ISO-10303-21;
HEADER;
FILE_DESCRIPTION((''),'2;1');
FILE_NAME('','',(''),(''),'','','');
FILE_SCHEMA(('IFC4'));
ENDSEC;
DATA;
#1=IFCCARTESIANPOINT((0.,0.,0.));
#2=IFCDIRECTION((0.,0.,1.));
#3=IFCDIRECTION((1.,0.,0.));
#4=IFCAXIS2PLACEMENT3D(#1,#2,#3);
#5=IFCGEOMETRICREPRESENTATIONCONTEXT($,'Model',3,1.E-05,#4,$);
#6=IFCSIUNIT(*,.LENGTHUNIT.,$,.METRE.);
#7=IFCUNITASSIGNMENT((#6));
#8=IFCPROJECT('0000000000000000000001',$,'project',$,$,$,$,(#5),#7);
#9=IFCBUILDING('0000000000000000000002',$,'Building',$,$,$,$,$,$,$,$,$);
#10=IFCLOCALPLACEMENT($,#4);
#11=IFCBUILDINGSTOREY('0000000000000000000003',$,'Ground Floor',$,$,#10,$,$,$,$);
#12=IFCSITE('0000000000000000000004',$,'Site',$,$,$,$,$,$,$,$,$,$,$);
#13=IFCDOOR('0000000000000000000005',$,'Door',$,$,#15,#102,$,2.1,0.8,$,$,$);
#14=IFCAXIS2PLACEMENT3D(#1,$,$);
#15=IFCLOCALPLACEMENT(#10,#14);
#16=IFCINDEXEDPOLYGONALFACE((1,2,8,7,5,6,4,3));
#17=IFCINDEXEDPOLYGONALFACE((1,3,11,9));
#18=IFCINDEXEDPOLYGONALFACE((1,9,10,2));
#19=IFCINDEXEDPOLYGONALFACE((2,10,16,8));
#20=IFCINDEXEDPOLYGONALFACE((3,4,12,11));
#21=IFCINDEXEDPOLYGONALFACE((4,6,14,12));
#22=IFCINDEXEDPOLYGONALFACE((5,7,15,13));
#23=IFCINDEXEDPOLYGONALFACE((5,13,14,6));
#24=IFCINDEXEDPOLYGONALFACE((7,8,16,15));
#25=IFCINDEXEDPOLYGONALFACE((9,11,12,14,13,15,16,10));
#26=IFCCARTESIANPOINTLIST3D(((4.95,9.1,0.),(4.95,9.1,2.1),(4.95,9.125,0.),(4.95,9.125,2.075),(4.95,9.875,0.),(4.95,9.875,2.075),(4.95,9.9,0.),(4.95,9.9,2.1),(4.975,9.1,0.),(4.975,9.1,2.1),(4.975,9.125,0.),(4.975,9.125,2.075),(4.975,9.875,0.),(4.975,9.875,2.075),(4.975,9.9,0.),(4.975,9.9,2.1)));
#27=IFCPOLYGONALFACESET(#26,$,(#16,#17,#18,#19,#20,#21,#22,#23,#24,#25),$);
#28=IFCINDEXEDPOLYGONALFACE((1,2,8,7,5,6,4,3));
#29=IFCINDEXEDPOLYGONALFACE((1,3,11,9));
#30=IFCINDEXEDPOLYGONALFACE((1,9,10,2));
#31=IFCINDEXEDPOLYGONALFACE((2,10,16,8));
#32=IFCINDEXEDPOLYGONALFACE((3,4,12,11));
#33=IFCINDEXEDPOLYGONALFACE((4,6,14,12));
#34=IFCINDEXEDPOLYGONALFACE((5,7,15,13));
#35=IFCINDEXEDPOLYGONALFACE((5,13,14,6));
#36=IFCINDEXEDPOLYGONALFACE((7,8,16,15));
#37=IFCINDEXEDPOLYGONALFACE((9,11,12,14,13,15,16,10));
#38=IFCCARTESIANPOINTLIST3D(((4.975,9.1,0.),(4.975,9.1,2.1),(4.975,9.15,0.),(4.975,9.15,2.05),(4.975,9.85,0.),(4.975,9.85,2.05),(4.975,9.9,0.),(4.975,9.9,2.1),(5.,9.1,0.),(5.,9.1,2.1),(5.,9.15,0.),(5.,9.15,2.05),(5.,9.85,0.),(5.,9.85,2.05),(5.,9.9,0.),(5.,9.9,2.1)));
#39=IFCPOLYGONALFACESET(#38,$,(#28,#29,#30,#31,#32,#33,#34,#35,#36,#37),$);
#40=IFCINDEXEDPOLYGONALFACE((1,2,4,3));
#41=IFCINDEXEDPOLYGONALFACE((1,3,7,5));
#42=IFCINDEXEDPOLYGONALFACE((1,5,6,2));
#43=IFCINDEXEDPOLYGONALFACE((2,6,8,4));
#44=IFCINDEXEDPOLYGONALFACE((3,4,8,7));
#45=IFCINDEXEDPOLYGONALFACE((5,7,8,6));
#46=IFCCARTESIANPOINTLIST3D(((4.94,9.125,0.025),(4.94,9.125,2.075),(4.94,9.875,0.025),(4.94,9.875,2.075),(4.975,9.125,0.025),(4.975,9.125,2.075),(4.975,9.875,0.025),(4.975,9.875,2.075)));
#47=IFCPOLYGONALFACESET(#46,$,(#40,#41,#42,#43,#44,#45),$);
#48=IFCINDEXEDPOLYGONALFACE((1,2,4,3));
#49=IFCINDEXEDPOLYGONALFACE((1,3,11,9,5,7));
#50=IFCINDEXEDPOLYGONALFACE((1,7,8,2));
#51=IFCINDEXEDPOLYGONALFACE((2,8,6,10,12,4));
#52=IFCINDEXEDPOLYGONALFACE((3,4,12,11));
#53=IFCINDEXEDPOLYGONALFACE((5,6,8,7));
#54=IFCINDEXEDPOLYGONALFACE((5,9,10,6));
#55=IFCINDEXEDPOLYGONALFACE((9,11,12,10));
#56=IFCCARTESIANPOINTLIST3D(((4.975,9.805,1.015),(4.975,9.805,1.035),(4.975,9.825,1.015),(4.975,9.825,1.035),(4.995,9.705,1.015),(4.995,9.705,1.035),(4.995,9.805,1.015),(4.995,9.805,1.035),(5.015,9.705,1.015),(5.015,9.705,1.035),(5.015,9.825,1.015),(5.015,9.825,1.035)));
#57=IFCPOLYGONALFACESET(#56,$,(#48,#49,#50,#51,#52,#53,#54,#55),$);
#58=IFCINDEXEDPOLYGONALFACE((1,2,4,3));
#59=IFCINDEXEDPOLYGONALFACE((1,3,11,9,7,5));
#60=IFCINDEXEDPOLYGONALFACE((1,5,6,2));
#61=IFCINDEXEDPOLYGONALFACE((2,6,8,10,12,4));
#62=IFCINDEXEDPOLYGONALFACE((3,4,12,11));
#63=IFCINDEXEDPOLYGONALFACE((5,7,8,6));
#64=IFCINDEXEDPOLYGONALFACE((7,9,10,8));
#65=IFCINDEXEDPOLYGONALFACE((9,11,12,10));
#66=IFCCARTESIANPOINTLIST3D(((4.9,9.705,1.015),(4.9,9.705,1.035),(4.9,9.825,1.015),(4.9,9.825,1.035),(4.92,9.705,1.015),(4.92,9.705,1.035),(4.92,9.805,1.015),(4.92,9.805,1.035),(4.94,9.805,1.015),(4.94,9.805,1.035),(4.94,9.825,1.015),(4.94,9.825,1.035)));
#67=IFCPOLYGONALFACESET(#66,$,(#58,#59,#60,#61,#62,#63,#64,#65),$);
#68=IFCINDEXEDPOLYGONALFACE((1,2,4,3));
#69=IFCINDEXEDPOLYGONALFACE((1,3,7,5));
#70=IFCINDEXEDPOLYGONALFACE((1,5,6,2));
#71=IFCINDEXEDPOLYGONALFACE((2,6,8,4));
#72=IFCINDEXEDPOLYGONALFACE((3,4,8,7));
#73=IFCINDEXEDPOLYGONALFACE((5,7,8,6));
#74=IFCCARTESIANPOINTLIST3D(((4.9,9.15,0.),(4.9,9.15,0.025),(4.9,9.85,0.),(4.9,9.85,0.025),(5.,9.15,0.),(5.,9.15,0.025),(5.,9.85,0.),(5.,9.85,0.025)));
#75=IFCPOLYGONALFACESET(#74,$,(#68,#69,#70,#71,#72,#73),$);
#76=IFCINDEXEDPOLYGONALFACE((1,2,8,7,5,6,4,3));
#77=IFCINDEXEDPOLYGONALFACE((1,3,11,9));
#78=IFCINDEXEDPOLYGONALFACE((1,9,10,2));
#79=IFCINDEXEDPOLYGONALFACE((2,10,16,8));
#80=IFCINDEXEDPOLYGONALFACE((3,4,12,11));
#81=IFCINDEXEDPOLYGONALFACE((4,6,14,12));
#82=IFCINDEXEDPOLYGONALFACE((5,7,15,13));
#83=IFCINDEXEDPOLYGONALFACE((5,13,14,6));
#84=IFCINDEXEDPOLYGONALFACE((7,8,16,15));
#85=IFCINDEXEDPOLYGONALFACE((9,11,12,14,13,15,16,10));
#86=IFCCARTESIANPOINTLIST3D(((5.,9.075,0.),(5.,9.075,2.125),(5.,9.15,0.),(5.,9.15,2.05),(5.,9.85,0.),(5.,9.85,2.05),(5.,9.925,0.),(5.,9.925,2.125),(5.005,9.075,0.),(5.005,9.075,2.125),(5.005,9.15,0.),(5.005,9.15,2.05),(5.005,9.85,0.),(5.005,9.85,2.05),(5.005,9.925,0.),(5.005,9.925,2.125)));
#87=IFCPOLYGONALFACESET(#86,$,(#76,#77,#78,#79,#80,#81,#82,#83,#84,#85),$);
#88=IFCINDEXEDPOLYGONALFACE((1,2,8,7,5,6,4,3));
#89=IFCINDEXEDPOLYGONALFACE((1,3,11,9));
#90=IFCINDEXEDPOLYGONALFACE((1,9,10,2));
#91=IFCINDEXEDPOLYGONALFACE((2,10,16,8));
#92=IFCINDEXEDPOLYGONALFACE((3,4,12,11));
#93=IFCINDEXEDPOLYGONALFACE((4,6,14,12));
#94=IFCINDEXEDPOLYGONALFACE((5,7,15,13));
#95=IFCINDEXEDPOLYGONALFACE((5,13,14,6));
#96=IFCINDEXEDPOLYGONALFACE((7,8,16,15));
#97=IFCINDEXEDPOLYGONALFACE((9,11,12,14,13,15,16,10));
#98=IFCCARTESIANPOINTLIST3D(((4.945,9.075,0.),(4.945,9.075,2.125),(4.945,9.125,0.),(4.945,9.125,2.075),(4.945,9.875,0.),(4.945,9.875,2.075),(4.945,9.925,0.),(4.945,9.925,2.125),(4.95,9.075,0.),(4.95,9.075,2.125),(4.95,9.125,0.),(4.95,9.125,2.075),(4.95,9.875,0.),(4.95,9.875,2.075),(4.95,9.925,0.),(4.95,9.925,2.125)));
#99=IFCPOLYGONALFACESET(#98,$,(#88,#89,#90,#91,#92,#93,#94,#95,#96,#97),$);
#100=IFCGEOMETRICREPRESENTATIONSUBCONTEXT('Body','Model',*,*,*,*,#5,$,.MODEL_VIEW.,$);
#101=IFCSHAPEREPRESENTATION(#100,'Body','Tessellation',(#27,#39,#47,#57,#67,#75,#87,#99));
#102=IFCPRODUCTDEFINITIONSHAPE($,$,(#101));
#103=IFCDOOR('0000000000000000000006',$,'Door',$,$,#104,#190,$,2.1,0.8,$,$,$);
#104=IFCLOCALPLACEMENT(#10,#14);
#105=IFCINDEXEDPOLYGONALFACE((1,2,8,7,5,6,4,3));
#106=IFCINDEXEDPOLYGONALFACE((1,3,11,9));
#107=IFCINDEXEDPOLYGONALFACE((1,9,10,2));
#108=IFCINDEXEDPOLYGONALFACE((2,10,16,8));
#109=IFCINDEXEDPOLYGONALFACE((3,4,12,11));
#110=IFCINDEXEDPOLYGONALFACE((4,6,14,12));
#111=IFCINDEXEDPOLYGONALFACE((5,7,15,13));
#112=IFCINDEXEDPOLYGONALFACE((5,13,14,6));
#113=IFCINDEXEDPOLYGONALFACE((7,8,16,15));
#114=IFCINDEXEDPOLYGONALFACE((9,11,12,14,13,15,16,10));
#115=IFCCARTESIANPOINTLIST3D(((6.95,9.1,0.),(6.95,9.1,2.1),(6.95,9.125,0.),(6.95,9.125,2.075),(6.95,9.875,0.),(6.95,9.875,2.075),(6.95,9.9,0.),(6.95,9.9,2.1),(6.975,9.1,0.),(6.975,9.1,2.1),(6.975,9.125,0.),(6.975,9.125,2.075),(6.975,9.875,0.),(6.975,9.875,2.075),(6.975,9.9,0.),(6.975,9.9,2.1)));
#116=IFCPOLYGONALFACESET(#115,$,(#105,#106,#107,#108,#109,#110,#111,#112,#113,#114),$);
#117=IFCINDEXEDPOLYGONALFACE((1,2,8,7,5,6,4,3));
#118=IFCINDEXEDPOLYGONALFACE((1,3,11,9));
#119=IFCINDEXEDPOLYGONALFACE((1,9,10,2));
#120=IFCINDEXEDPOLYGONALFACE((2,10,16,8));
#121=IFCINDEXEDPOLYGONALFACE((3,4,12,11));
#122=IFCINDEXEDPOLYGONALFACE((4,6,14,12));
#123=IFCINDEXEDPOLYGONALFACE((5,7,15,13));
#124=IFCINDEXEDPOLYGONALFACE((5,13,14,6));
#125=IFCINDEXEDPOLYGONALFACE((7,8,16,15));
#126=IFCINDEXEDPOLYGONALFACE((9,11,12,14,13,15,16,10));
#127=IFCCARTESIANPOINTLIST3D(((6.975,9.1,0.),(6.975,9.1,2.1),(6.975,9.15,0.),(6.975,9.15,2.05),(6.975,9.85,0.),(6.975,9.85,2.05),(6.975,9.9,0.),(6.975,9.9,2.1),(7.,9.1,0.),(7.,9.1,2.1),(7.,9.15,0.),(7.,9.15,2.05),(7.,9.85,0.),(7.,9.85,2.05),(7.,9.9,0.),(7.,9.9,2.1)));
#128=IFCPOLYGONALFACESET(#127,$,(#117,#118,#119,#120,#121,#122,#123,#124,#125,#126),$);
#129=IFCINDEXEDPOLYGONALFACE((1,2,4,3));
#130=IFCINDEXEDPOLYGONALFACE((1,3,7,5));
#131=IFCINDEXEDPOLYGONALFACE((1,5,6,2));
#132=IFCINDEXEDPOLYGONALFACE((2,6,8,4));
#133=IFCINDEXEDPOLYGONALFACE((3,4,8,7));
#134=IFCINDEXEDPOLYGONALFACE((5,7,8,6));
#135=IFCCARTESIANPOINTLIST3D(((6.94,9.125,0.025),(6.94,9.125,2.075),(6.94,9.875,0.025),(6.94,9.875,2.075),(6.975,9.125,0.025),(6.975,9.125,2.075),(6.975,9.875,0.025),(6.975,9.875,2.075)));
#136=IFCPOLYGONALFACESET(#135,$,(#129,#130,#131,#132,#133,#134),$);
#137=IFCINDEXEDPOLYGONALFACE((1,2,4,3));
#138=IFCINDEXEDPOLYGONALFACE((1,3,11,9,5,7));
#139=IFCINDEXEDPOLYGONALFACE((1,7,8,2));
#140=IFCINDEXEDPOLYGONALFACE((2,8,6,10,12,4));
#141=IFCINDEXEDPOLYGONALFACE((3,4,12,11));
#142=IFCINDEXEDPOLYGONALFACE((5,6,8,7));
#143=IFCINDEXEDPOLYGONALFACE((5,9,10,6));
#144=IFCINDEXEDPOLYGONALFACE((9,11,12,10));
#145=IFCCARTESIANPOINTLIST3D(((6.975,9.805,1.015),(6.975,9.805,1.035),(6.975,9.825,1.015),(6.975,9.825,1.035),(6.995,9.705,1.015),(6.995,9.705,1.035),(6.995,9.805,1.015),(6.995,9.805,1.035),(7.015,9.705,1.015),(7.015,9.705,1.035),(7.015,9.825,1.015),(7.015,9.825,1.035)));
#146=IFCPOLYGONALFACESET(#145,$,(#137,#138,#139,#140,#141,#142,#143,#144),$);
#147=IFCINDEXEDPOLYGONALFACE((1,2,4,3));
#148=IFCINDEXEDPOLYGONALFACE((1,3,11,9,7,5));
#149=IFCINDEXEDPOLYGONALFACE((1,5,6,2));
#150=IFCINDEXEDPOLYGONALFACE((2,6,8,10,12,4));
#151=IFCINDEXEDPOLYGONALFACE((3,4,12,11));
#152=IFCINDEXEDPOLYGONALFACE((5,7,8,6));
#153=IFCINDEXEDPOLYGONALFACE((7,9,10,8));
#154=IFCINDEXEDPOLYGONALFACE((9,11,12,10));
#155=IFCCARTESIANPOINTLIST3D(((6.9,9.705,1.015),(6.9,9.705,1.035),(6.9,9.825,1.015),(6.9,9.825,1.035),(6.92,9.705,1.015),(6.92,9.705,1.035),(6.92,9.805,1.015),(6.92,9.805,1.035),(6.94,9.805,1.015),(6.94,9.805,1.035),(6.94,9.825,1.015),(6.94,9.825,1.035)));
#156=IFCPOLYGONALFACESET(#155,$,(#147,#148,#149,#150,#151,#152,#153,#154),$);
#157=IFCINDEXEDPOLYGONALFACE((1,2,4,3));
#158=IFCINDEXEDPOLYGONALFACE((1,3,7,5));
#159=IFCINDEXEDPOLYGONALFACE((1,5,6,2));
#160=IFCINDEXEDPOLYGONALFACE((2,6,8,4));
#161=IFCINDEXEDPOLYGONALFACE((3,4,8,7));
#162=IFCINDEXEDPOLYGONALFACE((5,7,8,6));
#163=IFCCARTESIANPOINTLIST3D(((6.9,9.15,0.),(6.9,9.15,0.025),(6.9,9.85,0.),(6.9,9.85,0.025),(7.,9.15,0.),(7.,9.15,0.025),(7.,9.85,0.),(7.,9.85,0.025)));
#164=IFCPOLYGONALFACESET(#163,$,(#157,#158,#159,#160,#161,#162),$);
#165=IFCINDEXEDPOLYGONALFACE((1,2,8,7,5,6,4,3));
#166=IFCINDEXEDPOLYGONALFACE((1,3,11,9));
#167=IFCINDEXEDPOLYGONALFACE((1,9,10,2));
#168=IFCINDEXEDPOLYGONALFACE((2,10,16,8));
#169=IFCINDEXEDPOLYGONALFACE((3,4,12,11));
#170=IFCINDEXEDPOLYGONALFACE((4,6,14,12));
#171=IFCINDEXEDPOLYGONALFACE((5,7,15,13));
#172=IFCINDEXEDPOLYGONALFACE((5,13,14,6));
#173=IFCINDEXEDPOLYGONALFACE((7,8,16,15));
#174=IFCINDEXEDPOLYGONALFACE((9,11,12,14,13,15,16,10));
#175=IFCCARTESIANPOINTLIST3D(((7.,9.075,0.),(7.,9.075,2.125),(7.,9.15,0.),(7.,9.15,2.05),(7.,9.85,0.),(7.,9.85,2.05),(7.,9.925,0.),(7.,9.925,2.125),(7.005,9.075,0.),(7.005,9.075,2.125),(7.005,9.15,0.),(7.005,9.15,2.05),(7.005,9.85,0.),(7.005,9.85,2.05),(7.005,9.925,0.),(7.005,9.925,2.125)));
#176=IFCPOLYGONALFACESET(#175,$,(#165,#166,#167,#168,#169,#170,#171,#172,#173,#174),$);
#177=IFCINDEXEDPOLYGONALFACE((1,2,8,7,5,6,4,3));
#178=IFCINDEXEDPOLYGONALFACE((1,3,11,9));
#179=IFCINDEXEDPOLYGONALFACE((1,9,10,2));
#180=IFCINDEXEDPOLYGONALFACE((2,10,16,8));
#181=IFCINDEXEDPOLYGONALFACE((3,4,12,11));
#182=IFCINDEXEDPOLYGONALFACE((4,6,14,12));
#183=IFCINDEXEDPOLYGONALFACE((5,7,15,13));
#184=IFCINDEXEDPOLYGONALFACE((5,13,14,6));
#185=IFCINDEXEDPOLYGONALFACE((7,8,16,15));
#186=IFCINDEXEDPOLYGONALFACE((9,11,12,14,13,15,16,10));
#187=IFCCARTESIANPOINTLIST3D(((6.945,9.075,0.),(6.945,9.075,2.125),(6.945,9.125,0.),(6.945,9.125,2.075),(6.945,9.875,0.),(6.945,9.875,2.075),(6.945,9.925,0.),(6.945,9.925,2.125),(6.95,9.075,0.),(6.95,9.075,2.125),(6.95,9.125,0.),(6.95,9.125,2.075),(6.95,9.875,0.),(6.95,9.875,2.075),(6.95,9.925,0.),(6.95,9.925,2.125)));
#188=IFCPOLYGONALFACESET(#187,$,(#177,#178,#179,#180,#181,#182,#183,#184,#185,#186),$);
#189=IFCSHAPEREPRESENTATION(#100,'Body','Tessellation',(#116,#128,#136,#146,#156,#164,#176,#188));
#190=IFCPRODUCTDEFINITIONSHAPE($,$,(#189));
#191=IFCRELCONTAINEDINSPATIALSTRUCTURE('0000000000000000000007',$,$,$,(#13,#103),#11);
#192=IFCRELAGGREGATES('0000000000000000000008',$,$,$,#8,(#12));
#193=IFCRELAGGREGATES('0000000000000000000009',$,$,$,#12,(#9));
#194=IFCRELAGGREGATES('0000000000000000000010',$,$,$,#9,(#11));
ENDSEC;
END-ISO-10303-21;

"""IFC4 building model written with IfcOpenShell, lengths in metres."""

from ifc_helpers import new_model, si_unit, frame, origin_with_axes, place, context, subcontext, project, spatial, line, indexed_curve, outline, extrude, element, save


model = new_model("IFC4")

# Units and contexts
model_context = context("Model", 3, precision=1e-05, world=origin_with_axes())
body_context = subcontext(model_context, "Body", "Model", "MODEL_VIEW")
ifc_project = project(units=[si_unit("LENGTHUNIT", "METRE")], contexts=[model_context])

# Site, building, storey
site = spatial("IfcSite", under=ifc_project, Name="Site")
building = spatial("IfcBuilding", under=site, Name="Building")
storey_placement = place(None, origin_with_axes())
storey = spatial("IfcBuildingStorey", under=building, at=storey_placement, Name="Ground Floor")

# Doors
door_1_placement = place(storey_placement, frame((5.0, 9.1, 0.0), z_axis=(0.0, 0.0, 1.0), x_axis=(0.0, 1.0, 0.0)))
element("IfcDoor", 1, at=door_1_placement, inside=storey, Name="Door", OverallHeight=2.1, OverallWidth=0.8, context=body_context, shape_type="SweptSolid", body=[
    extrude(outline(indexed_curve([(0.0, 0.0), (0.0, 2.1), (0.8, 2.1), (0.8, 0.0), (0.775, 0.0), (0.775, 2.075), (0.025, 2.075), (0.025, 0.0)], segments=[line(1, 2, 3, 4, 5, 6, 7, 8, 1)])), frame((0.0, 0.025, 0.0), z_axis=(0.0, -1.0, 0.0), x_axis=(1.0, 0.0, 0.0)), (0.0, 0.0, -1.0), 0.025),
    extrude(outline(indexed_curve([(0.0, 0.0), (0.0, 2.1), (0.8, 2.1), (0.8, 0.0), (0.75, 0.0), (0.75, 2.05), (0.05, 2.05), (0.05, 0.0)], segments=[line(1, 2, 3, 4, 5, 6, 7, 8, 1)])), frame((0.0, 0.0, 0.0), z_axis=(0.0, -1.0, 0.0), x_axis=(1.0, 0.0, 0.0)), (0.0, 0.0, -1.0), 0.025),
    extrude(outline(indexed_curve([(0.0, 0.0), (0.75, 0.0), (0.75, 0.035), (0.0, 0.035)], segments=[line(1, 2, 3, 4, 1)])), frame((0.025, 0.025, 0.025), z_axis=(0.0, 0.0, 1.0), x_axis=(1.0, 0.0, 0.0)), (0.0, 0.0, 1.0), 2.05),
    extrude(outline(indexed_curve([(0.0, 0.0), (0.0, -0.04), (-0.12, -0.04), (-0.12, -0.02), (-0.02, -0.02), (-0.02, 0.0)], segments=[line(1, 2, 3, 4, 5, 6, 1)])), frame((0.725, 0.025, 1.015), z_axis=(0.0, 0.0, 1.0), x_axis=(1.0, 0.0, 0.0)), (0.0, 0.0, 1.0), 0.02),
    extrude(outline(indexed_curve([(0.0, 0.0), (0.0, 0.04), (-0.12, 0.04), (-0.12, 0.02), (-0.02, 0.02), (-0.02, 0.0)], segments=[line(1, 2, 3, 4, 5, 6, 1)])), frame((0.725, 0.06, 1.015), z_axis=(0.0, 0.0, 1.0), x_axis=(1.0, 0.0, 0.0)), (0.0, 0.0, 1.0), 0.02),
    extrude(outline(indexed_curve([(0.0, 0.0), (0.7, 0.0), (0.7, 0.1), (0.0, 0.1)], segments=[line(1, 2, 3, 4, 1)])), frame((0.05, 0.0, 0.0), z_axis=(0.0, 0.0, 1.0), x_axis=(1.0, 0.0, 0.0)), (0.0, 0.0, 1.0), 0.025),
    extrude(outline(indexed_curve([(0.0, 0.0), (0.0, 2.125), (0.85, 2.125), (0.85, 0.0), (0.775, 0.0), (0.775, 2.05), (0.075, 2.05), (0.075, 0.0)], segments=[line(1, 2, 3, 4, 5, 6, 7, 8, 1)])), frame((-0.025, -0.005, 0.0), z_axis=(0.0, -1.0, 0.0), x_axis=(1.0, 0.0, 0.0)), (0.0, 0.0, -1.0), 0.005),
    extrude(outline(indexed_curve([(0.0, 0.0), (0.0, 2.125), (0.85, 2.125), (0.85, 0.0), (0.8, 0.0), (0.8, 2.075), (0.05, 2.075), (0.05, 0.0)], segments=[line(1, 2, 3, 4, 5, 6, 7, 8, 1)])), frame((-0.025, 0.05, 0.0), z_axis=(0.0, -1.0, 0.0), x_axis=(1.0, 0.0, 0.0)), (0.0, 0.0, -1.0), 0.005),
])
door_2_placement = place(storey_placement, frame((7.0, 9.1, 0.0), z_axis=(0.0, 0.0, 1.0), x_axis=(0.0, 1.0, 0.0)))
element("IfcDoor", 2, at=door_2_placement, inside=storey, Name="Door", OverallHeight=2.1, OverallWidth=0.8, context=body_context, shape_type="SweptSolid", body=[
    extrude(outline(indexed_curve([(0.0, 0.0), (0.0, 2.1), (0.8, 2.1), (0.8, 0.0), (0.775, 0.0), (0.775, 2.075), (0.025, 2.075), (0.025, 0.0)], segments=[line(1, 2, 3, 4, 5, 6, 7, 8, 1)])), frame((0.0, 0.025, 0.0), z_axis=(0.0, -1.0, 0.0), x_axis=(1.0, 0.0, 0.0)), (0.0, 0.0, -1.0), 0.025),
    extrude(outline(indexed_curve([(0.0, 0.0), (0.0, 2.1), (0.8, 2.1), (0.8, 0.0), (0.75, 0.0), (0.75, 2.05), (0.05, 2.05), (0.05, 0.0)], segments=[line(1, 2, 3, 4, 5, 6, 7, 8, 1)])), frame((0.0, 0.0, 0.0), z_axis=(0.0, -1.0, 0.0), x_axis=(1.0, 0.0, 0.0)), (0.0, 0.0, -1.0), 0.025),
    extrude(outline(indexed_curve([(0.0, 0.0), (0.75, 0.0), (0.75, 0.035), (0.0, 0.035)], segments=[line(1, 2, 3, 4, 1)])), frame((0.025, 0.025, 0.025), z_axis=(0.0, 0.0, 1.0), x_axis=(1.0, 0.0, 0.0)), (0.0, 0.0, 1.0), 2.05),
    extrude(outline(indexed_curve([(0.0, 0.0), (0.0, -0.04), (-0.12, -0.04), (-0.12, -0.02), (-0.02, -0.02), (-0.02, 0.0)], segments=[line(1, 2, 3, 4, 5, 6, 1)])), frame((0.725, 0.025, 1.015), z_axis=(0.0, 0.0, 1.0), x_axis=(1.0, 0.0, 0.0)), (0.0, 0.0, 1.0), 0.02),
    extrude(outline(indexed_curve([(0.0, 0.0), (0.0, 0.04), (-0.12, 0.04), (-0.12, 0.02), (-0.02, 0.02), (-0.02, 0.0)], segments=[line(1, 2, 3, 4, 5, 6, 1)])), frame((0.725, 0.06, 1.015), z_axis=(0.0, 0.0, 1.0), x_axis=(1.0, 0.0, 0.0)), (0.0, 0.0, 1.0), 0.02),
    extrude(outline(indexed_curve([(0.0, 0.0), (0.7, 0.0), (0.7, 0.1), (0.0, 0.1)], segments=[line(1, 2, 3, 4, 1)])), frame((0.05, 0.0, 0.0), z_axis=(0.0, 0.0, 1.0), x_axis=(1.0, 0.0, 0.0)), (0.0, 0.0, 1.0), 0.025),
    extrude(outline(indexed_curve([(0.0, 0.0), (0.0, 2.125), (0.85, 2.125), (0.85, 0.0), (0.775, 0.0), (0.775, 2.05), (0.075, 2.05), (0.075, 0.0)], segments=[line(1, 2, 3, 4, 5, 6, 7, 8, 1)])), frame((-0.025, -0.005, 0.0), z_axis=(0.0, -1.0, 0.0), x_axis=(1.0, 0.0, 0.0)), (0.0, 0.0, -1.0), 0.005),
    extrude(outline(indexed_curve([(0.0, 0.0), (0.0, 2.125), (0.85, 2.125), (0.85, 0.0), (0.8, 0.0), (0.8, 2.075), (0.05, 2.075), (0.05, 0.0)], segments=[line(1, 2, 3, 4, 5, 6, 7, 8, 1)])), frame((-0.025, 0.05, 0.0), z_axis=(0.0, -1.0, 0.0), x_axis=(1.0, 0.0, 0.0)), (0.0, 0.0, -1.0), 0.005),
])

save(model, "model.ifc")
